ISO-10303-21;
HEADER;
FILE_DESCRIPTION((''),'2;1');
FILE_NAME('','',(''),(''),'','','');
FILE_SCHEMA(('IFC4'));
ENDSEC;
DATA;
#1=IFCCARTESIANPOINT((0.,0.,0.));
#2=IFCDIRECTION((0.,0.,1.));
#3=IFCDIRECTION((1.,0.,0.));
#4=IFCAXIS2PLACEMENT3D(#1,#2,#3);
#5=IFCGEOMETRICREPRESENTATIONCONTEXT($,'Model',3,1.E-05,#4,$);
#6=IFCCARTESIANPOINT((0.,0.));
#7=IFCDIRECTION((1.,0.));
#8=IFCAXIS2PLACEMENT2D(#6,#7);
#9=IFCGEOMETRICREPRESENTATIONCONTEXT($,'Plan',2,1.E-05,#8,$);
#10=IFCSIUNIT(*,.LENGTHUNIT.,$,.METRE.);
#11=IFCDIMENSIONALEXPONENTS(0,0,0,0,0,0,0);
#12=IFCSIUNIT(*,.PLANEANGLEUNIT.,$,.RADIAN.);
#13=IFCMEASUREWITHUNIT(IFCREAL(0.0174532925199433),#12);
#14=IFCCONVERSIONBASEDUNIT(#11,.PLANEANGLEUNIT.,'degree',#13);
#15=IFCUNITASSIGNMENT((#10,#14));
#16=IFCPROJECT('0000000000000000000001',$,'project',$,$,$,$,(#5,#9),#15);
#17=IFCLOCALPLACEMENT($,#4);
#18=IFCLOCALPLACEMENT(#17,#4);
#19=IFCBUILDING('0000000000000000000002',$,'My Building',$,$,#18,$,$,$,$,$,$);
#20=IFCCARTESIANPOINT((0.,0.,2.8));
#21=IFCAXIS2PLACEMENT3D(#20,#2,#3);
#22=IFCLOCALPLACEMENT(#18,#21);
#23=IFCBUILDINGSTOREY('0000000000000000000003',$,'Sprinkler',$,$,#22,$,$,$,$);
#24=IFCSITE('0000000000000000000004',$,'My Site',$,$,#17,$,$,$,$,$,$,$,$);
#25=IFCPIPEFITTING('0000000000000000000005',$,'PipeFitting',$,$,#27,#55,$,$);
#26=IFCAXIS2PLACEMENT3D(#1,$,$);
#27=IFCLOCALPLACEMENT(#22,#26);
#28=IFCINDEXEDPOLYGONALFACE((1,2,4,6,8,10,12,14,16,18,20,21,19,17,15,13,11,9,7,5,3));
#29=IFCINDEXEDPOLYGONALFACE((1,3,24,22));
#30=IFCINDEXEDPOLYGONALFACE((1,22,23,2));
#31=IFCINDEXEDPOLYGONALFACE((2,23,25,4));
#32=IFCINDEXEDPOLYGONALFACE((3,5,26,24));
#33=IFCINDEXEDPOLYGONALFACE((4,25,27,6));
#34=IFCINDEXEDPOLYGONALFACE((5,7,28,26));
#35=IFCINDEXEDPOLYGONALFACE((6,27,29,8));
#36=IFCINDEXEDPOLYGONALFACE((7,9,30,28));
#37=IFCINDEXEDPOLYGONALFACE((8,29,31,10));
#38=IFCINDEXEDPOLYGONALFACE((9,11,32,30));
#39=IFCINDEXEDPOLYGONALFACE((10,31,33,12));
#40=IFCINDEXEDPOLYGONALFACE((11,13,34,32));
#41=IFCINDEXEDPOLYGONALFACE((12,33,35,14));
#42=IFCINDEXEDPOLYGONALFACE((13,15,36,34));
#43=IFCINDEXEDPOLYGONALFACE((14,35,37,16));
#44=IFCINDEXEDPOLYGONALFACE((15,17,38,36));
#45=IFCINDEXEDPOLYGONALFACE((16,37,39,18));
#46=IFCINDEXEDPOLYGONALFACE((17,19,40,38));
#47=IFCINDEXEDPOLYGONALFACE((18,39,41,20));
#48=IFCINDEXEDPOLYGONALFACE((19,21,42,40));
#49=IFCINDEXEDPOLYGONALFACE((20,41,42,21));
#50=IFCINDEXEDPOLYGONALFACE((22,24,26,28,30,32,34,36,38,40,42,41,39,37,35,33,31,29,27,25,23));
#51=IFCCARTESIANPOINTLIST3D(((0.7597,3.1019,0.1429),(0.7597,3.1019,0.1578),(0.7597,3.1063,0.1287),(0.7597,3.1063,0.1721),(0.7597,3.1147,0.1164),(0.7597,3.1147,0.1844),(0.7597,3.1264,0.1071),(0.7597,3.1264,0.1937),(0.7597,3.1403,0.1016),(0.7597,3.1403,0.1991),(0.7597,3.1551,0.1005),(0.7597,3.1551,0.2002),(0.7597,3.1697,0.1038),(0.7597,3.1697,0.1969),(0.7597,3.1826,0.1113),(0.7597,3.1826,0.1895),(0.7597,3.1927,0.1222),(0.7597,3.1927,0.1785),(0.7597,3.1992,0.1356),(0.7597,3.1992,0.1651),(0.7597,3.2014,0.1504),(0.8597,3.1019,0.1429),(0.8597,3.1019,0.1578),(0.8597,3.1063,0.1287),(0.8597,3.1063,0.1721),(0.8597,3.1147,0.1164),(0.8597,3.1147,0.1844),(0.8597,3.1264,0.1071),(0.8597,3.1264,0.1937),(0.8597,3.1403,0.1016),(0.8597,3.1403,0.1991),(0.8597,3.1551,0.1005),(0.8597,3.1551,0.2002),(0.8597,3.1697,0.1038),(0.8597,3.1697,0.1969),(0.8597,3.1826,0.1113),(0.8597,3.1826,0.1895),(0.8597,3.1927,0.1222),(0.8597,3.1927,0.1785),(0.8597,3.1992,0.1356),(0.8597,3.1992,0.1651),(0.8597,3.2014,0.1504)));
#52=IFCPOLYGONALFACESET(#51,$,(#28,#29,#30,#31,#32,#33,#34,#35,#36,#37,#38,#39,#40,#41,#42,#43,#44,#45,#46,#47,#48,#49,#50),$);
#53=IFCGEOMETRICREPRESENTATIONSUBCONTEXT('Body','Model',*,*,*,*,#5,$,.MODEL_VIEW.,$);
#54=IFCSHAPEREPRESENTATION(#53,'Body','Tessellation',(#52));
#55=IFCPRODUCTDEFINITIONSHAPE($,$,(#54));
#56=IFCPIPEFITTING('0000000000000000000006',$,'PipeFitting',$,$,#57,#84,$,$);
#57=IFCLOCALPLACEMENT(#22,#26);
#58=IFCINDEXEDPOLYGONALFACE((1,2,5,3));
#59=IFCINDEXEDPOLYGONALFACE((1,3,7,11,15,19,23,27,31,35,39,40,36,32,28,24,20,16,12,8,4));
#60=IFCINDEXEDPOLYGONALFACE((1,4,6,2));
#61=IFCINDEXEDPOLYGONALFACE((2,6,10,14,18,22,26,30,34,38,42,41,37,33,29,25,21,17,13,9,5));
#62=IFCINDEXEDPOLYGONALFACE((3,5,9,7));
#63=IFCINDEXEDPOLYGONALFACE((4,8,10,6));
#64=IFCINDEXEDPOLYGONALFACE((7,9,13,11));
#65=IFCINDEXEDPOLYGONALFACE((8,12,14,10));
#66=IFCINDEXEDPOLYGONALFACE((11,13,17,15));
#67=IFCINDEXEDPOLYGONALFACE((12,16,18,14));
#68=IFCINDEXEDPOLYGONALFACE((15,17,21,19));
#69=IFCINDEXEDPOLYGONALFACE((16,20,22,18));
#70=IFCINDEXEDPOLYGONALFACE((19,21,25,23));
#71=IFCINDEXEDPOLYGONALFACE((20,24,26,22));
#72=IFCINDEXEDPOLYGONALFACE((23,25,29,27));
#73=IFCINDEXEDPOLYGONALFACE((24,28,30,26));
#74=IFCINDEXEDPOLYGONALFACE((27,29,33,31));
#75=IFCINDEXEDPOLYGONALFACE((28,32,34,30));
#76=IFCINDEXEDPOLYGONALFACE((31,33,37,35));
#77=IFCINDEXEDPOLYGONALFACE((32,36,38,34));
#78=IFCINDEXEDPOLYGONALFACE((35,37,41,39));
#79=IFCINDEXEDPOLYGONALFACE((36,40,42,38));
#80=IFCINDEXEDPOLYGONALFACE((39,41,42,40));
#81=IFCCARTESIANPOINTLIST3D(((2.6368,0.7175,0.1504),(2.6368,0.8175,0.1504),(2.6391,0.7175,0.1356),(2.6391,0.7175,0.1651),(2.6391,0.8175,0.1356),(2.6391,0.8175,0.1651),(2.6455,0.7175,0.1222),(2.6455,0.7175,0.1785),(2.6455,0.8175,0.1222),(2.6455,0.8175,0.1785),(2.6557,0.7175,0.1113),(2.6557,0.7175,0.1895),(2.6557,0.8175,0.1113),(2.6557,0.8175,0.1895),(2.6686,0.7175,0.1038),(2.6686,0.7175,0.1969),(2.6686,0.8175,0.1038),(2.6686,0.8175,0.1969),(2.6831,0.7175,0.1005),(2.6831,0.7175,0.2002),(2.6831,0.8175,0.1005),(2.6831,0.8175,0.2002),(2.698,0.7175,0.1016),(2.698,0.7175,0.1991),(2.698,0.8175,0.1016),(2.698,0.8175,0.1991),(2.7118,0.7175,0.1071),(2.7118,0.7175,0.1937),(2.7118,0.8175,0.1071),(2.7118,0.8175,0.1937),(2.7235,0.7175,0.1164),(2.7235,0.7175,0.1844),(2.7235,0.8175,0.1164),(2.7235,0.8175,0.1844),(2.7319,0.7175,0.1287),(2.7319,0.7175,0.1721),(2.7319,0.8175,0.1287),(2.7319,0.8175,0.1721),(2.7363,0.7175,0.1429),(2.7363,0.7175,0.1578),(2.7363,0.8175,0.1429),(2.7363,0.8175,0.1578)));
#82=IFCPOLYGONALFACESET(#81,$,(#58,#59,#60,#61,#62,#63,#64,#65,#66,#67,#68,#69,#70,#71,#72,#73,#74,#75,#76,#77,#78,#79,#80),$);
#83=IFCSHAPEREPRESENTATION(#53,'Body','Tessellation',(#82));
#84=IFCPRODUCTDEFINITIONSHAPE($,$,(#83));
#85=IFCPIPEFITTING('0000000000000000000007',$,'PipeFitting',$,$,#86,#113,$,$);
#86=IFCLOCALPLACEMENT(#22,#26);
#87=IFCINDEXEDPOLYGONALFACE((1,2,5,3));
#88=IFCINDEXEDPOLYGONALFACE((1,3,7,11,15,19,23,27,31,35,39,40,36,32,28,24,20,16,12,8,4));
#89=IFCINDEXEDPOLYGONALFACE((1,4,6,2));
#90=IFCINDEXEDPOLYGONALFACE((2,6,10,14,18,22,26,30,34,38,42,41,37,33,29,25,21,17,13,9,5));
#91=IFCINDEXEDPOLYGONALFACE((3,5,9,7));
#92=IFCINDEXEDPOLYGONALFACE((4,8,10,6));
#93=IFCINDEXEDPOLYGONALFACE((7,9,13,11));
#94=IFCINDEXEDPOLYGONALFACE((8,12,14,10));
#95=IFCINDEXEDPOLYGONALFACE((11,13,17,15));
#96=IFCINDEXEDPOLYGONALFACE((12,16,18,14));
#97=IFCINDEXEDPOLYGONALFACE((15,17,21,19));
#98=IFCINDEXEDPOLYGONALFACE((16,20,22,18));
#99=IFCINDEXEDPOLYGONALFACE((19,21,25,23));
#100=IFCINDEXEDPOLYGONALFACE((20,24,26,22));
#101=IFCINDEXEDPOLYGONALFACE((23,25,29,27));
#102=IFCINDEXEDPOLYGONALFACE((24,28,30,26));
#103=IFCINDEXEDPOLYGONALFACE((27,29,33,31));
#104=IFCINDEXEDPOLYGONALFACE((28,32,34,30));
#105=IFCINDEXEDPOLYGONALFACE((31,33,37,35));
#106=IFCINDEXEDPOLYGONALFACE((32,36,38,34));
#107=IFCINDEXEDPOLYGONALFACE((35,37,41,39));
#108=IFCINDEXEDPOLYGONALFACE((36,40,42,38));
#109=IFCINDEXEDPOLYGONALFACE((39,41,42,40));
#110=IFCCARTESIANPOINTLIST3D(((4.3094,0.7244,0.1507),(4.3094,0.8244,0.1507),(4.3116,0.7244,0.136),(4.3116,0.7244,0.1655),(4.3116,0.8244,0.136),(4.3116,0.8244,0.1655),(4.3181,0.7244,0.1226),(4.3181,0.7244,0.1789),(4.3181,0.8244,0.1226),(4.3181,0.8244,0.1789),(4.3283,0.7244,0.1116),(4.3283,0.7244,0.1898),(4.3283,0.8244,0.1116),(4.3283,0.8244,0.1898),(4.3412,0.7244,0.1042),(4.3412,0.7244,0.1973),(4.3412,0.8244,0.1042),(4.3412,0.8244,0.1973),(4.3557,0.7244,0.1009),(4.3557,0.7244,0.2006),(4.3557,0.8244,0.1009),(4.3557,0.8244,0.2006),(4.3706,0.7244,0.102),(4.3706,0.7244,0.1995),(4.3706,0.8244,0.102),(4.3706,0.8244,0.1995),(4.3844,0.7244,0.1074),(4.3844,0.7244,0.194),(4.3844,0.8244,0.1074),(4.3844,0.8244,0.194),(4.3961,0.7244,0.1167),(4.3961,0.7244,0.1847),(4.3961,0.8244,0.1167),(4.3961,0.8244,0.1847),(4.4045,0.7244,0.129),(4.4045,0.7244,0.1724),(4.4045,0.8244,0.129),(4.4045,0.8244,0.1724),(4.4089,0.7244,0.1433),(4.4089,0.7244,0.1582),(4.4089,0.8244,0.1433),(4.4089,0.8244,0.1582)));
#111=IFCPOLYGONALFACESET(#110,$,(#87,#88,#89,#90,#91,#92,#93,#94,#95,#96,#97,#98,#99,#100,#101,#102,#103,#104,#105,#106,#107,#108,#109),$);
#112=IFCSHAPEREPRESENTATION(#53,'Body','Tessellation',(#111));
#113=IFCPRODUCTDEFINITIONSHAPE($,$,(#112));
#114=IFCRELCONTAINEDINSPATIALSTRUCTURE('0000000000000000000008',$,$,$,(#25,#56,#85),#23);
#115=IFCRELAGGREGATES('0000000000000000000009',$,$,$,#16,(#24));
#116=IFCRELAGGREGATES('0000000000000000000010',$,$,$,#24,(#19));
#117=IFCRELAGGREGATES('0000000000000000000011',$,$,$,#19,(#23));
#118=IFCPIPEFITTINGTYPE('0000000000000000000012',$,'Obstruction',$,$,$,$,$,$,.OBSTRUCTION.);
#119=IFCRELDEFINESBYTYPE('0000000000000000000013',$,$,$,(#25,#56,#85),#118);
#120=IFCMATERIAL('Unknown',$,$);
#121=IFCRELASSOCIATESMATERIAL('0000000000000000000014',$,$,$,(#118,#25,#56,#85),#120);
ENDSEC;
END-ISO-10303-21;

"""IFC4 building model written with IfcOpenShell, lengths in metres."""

from ifc_helpers import new_model, entity, si_unit, converted_unit, frame, origin_with_axes, origin_2d_with_axis, place, context, subcontext, project, spatial, circle, extrude, material, material_profile, profile_set, profile_usage, type_object, element, save


model = new_model("IFC4")

# Units and contexts
model_context = context("Model", 3, precision=1e-05, world=origin_with_axes())
plan_context = context("Plan", 2, precision=1e-05, world=origin_2d_with_axis())
body_context = subcontext(model_context, "Body", "Model", "MODEL_VIEW")
ifc_project = project(units=[si_unit("LENGTHUNIT", "METRE"), converted_unit("PLANEANGLEUNIT", "degree", entity("IfcReal", 0.0174532925199433), si_unit("PLANEANGLEUNIT", "RADIAN"), dimensions=[0, 0, 0, 0, 0, 0, 0])], contexts=[model_context, plan_context])

# Site, building, storey
site_placement = place(None, origin_with_axes())
site = spatial("IfcSite", under=ifc_project, at=site_placement, Name="My Site")
building_placement = place(site_placement, origin_with_axes())
building = spatial("IfcBuilding", under=site, at=building_placement, Name="My Building")
storey_placement = place(building_placement, frame((0.0, 0.0, 2.8), z_axis=(0.0, 0.0, 1.0), x_axis=(1.0, 0.0, 0.0)))
storey = spatial("IfcBuildingStorey", under=building, at=storey_placement, Name="Sprinkler")

# Shared definitions
ifc_material = material(Name="Unknown")

# Pipe fittings
ifc_material_profile_1 = material_profile(ifc_material, circle(Radius=0.05))
ifc_profile_set_1 = profile_set([ifc_material_profile_1])
pipe_fitting_type_1 = type_object("IfcPipeFittingType", Name="Obstruction", PredefinedType="OBSTRUCTION", material=ifc_profile_set_1)
ifc_profile_usage_1 = profile_usage(ifc_profile_set_1, cardinal=5)
pipe_fitting_1_placement = place(storey_placement, frame((0.7597, 3.1514, 0.1504), z_axis=(1.0, 0.0, 0.0), x_axis=(0.0, 1.0, 0.0)))
element("IfcPipeFitting", 1, at=pipe_fitting_1_placement, inside=storey, type_object=pipe_fitting_type_1, material=ifc_profile_usage_1, Name="PipeFitting", context=body_context, shape_type="SweptSolid", body=[
    extrude(circle(Radius=0.05), origin_with_axes(), (0.0, 0.0, 1.0), 0.1),
])
ifc_profile_usage_2 = profile_usage(ifc_profile_set_1, cardinal=5)
pipe_fitting_2_placement = place(storey_placement, frame((2.6868, 0.7175, 0.1504), z_axis=(0.0, 1.0, 0.0), x_axis=(-1.0, 0.0, 0.0)))
element("IfcPipeFitting", 2, at=pipe_fitting_2_placement, inside=storey, type_object=pipe_fitting_type_1, material=ifc_profile_usage_2, Name="PipeFitting", context=body_context, shape_type="SweptSolid", body=[
    extrude(circle(Radius=0.05), origin_with_axes(), (0.0, 0.0, 1.0), 0.1),
])
ifc_profile_usage_3 = profile_usage(ifc_profile_set_1, cardinal=5)
pipe_fitting_3_placement = place(storey_placement, frame((4.3594, 0.7244, 0.1507), z_axis=(0.0, 1.0, 0.000005), x_axis=(-1.0, 0.0, 0.0)))
element("IfcPipeFitting", 3, at=pipe_fitting_3_placement, inside=storey, type_object=pipe_fitting_type_1, material=ifc_profile_usage_3, Name="PipeFitting", context=body_context, shape_type="SweptSolid", body=[
    extrude(circle(Radius=0.05), origin_with_axes(), (0.0, 0.0, 1.0), 0.1),
])

save(model, "model.ifc")
